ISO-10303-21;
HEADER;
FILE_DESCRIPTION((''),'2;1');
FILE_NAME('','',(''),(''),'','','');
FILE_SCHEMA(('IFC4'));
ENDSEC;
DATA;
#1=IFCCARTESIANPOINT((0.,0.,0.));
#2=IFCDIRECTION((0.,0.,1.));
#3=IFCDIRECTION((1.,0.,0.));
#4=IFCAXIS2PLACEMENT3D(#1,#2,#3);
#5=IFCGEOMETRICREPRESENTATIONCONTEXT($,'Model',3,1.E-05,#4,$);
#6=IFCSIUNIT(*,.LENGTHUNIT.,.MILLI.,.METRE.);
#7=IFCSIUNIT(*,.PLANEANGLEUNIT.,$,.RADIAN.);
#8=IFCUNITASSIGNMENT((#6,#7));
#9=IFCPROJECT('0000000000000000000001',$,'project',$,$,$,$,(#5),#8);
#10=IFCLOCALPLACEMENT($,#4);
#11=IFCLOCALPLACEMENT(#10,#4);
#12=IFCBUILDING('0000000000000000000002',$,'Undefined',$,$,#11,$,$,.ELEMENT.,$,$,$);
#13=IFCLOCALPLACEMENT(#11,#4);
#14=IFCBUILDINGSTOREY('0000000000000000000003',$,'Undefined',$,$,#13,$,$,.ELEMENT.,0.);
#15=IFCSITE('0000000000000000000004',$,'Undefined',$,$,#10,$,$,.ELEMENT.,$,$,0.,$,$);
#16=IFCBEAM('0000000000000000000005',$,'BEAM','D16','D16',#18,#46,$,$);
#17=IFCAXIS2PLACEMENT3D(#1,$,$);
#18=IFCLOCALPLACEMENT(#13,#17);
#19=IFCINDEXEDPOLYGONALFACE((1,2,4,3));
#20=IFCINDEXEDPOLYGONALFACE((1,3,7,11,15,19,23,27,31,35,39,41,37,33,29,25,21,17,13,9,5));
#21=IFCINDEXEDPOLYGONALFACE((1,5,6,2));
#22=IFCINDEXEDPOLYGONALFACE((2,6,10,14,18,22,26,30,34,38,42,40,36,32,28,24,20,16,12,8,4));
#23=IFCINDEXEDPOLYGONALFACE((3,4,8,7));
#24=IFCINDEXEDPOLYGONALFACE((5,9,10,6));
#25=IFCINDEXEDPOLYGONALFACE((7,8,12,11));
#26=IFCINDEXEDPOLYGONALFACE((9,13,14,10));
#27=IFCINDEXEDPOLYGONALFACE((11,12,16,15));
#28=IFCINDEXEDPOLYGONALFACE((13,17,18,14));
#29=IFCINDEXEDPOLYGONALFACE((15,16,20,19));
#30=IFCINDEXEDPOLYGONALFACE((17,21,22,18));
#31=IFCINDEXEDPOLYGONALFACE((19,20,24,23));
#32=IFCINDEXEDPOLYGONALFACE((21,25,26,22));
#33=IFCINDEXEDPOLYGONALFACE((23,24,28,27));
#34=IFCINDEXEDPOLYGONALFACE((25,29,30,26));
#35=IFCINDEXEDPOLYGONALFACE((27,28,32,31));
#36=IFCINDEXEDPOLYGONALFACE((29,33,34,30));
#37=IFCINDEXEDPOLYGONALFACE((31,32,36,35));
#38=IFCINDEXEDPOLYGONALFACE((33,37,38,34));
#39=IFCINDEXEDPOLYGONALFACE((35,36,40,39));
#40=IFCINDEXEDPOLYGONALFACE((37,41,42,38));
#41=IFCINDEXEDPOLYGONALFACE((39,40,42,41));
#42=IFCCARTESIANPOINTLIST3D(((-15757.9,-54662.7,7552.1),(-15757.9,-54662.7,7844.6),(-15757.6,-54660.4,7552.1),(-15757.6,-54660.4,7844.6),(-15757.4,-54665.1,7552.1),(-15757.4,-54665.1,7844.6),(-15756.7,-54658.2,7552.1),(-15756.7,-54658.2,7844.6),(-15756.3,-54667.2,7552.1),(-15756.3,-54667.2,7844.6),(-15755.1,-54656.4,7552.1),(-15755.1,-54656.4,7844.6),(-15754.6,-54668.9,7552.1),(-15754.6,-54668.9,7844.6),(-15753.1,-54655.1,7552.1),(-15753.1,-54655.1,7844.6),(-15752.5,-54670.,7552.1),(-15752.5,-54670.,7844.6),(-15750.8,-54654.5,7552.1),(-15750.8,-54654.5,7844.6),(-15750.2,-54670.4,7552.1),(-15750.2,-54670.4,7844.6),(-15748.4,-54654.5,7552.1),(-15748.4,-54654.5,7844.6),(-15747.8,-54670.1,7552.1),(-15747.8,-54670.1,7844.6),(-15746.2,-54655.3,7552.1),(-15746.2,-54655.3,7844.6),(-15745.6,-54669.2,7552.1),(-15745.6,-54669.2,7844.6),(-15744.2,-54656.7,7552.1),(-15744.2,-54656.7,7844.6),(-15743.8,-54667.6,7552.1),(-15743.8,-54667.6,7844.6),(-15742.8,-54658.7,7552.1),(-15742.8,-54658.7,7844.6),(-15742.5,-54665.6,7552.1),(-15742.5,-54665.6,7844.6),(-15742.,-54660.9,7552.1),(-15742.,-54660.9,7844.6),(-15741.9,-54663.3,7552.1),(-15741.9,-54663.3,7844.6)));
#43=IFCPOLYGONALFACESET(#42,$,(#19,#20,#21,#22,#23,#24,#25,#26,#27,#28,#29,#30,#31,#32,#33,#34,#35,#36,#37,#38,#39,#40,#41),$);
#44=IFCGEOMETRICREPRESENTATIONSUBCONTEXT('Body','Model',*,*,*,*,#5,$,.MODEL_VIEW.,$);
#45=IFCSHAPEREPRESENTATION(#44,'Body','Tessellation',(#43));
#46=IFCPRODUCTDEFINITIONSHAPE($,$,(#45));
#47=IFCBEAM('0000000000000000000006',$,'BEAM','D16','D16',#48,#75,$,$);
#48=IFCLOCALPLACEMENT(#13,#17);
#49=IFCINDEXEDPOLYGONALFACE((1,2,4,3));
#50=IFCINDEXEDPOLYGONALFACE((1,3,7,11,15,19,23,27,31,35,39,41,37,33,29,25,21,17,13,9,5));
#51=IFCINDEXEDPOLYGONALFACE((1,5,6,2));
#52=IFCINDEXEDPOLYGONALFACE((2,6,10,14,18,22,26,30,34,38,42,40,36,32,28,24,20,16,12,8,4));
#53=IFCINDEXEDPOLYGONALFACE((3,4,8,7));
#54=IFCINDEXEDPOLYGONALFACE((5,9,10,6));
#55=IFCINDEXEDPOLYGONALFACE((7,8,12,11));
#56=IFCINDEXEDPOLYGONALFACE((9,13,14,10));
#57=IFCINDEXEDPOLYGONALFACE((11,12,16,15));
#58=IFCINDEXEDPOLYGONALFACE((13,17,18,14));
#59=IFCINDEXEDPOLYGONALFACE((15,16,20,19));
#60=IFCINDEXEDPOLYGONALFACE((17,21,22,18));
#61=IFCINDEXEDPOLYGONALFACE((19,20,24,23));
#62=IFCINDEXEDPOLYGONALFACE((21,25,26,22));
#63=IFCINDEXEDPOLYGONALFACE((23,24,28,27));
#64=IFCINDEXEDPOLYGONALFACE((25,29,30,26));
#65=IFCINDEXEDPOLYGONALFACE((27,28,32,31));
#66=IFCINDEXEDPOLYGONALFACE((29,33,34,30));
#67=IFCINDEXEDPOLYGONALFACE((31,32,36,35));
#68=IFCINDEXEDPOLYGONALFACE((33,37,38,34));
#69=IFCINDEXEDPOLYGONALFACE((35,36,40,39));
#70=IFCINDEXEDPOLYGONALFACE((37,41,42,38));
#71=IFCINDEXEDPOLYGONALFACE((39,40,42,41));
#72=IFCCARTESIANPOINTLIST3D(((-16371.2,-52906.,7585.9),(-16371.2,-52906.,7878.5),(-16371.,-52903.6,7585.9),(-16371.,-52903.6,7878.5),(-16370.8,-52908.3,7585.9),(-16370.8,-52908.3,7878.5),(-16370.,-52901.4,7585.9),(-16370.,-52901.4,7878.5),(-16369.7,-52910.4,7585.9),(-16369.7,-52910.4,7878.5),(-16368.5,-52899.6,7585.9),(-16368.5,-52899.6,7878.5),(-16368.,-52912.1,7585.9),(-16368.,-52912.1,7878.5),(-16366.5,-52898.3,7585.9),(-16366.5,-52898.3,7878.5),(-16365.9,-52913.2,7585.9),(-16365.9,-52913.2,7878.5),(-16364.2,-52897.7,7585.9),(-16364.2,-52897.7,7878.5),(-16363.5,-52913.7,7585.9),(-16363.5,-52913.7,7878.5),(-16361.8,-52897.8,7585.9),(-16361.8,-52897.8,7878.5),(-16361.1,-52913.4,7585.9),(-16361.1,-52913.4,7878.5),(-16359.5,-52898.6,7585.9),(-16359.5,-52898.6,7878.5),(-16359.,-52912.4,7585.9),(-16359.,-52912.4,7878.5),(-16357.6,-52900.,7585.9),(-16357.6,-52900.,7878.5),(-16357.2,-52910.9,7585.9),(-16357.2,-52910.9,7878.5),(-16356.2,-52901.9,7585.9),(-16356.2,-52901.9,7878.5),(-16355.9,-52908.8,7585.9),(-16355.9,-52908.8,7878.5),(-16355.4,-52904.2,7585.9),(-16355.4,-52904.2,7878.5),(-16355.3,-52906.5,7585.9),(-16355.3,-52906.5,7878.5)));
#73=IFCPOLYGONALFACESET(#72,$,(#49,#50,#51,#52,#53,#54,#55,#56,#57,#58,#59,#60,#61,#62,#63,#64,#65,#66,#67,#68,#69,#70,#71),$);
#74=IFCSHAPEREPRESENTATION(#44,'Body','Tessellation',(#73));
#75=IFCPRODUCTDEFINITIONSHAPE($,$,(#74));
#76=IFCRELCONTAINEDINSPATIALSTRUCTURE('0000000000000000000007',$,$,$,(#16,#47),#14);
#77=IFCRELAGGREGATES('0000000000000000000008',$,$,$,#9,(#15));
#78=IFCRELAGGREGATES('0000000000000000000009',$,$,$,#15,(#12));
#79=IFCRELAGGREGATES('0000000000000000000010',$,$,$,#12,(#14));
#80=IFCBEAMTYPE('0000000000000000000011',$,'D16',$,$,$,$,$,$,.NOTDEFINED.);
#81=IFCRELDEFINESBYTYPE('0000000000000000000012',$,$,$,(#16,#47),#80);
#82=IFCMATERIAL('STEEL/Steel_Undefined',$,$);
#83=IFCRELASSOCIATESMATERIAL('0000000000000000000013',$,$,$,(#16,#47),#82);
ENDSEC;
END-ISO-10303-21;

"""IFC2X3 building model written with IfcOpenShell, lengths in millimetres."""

from ifc_helpers import new_model, si_unit, frame, origin_with_axes, origin_2d_with_axis, place, context, subcontext, project, spatial, circle, extrude, material, type_object, element, save


model = new_model("IFC2X3")

# Units and contexts
model_context = context("Model", 3, precision=1e-05, world=origin_with_axes())
body_context = subcontext(model_context, "Body", "Model", "MODEL_VIEW")
ifc_project = project(units=[si_unit("LENGTHUNIT", "METRE", prefix="MILLI"), si_unit("PLANEANGLEUNIT", "RADIAN")], contexts=[model_context])

# Site, building, storey
site_placement = place(None, origin_with_axes())
site = spatial("IfcSite", under=ifc_project, at=site_placement, Name="Undefined", CompositionType="ELEMENT", RefElevation=0.0)
building_placement = place(site_placement, origin_with_axes())
building = spatial("IfcBuilding", under=site, at=building_placement, Name="Undefined", CompositionType="ELEMENT")
storey_placement = place(building_placement, origin_with_axes())
storey = spatial("IfcBuildingStorey", under=building, at=storey_placement, Name="Undefined", CompositionType="ELEMENT", Elevation=0.0)

# Shared definitions
ifc_material = material(Name="STEEL/Steel_Undefined")

# Beams
beam_type_1 = type_object("IfcBeamType", Name="D16", PredefinedType="NOTDEFINED")
for number, where, z_axis, x_axis, name in (
    (1, (-15749.9, -54662.4, 7844.6), (-0.915553, -0.402197, 0.0), (0.0, 0.0, -1.0), "BEAM"),
    (2, (-16363.2, -52905.7, 7878.5), (-0.915553, -0.402197, 0.0), (0.0, 0.0, -1.0), "BEAM"),
):
    element("IfcBeam", number, at=place(storey_placement, frame(where, z_axis=z_axis, x_axis=x_axis)), inside=storey, type_object=beam_type_1, material=ifc_material, Name=name, Description="D16", ObjectType="D16", context=body_context, shape_type="SweptSolid", body=[
        extrude(circle(Radius=8.0, at=origin_2d_with_axis()), frame((292.6, 0.0, 0.0), z_axis=(-1.0, 0.0, 0.0), x_axis=(0.0, -1.0, 0.0)), (0.0, 0.0, 1.0), 292.6),
    ])

save(model, "model.ifc")
